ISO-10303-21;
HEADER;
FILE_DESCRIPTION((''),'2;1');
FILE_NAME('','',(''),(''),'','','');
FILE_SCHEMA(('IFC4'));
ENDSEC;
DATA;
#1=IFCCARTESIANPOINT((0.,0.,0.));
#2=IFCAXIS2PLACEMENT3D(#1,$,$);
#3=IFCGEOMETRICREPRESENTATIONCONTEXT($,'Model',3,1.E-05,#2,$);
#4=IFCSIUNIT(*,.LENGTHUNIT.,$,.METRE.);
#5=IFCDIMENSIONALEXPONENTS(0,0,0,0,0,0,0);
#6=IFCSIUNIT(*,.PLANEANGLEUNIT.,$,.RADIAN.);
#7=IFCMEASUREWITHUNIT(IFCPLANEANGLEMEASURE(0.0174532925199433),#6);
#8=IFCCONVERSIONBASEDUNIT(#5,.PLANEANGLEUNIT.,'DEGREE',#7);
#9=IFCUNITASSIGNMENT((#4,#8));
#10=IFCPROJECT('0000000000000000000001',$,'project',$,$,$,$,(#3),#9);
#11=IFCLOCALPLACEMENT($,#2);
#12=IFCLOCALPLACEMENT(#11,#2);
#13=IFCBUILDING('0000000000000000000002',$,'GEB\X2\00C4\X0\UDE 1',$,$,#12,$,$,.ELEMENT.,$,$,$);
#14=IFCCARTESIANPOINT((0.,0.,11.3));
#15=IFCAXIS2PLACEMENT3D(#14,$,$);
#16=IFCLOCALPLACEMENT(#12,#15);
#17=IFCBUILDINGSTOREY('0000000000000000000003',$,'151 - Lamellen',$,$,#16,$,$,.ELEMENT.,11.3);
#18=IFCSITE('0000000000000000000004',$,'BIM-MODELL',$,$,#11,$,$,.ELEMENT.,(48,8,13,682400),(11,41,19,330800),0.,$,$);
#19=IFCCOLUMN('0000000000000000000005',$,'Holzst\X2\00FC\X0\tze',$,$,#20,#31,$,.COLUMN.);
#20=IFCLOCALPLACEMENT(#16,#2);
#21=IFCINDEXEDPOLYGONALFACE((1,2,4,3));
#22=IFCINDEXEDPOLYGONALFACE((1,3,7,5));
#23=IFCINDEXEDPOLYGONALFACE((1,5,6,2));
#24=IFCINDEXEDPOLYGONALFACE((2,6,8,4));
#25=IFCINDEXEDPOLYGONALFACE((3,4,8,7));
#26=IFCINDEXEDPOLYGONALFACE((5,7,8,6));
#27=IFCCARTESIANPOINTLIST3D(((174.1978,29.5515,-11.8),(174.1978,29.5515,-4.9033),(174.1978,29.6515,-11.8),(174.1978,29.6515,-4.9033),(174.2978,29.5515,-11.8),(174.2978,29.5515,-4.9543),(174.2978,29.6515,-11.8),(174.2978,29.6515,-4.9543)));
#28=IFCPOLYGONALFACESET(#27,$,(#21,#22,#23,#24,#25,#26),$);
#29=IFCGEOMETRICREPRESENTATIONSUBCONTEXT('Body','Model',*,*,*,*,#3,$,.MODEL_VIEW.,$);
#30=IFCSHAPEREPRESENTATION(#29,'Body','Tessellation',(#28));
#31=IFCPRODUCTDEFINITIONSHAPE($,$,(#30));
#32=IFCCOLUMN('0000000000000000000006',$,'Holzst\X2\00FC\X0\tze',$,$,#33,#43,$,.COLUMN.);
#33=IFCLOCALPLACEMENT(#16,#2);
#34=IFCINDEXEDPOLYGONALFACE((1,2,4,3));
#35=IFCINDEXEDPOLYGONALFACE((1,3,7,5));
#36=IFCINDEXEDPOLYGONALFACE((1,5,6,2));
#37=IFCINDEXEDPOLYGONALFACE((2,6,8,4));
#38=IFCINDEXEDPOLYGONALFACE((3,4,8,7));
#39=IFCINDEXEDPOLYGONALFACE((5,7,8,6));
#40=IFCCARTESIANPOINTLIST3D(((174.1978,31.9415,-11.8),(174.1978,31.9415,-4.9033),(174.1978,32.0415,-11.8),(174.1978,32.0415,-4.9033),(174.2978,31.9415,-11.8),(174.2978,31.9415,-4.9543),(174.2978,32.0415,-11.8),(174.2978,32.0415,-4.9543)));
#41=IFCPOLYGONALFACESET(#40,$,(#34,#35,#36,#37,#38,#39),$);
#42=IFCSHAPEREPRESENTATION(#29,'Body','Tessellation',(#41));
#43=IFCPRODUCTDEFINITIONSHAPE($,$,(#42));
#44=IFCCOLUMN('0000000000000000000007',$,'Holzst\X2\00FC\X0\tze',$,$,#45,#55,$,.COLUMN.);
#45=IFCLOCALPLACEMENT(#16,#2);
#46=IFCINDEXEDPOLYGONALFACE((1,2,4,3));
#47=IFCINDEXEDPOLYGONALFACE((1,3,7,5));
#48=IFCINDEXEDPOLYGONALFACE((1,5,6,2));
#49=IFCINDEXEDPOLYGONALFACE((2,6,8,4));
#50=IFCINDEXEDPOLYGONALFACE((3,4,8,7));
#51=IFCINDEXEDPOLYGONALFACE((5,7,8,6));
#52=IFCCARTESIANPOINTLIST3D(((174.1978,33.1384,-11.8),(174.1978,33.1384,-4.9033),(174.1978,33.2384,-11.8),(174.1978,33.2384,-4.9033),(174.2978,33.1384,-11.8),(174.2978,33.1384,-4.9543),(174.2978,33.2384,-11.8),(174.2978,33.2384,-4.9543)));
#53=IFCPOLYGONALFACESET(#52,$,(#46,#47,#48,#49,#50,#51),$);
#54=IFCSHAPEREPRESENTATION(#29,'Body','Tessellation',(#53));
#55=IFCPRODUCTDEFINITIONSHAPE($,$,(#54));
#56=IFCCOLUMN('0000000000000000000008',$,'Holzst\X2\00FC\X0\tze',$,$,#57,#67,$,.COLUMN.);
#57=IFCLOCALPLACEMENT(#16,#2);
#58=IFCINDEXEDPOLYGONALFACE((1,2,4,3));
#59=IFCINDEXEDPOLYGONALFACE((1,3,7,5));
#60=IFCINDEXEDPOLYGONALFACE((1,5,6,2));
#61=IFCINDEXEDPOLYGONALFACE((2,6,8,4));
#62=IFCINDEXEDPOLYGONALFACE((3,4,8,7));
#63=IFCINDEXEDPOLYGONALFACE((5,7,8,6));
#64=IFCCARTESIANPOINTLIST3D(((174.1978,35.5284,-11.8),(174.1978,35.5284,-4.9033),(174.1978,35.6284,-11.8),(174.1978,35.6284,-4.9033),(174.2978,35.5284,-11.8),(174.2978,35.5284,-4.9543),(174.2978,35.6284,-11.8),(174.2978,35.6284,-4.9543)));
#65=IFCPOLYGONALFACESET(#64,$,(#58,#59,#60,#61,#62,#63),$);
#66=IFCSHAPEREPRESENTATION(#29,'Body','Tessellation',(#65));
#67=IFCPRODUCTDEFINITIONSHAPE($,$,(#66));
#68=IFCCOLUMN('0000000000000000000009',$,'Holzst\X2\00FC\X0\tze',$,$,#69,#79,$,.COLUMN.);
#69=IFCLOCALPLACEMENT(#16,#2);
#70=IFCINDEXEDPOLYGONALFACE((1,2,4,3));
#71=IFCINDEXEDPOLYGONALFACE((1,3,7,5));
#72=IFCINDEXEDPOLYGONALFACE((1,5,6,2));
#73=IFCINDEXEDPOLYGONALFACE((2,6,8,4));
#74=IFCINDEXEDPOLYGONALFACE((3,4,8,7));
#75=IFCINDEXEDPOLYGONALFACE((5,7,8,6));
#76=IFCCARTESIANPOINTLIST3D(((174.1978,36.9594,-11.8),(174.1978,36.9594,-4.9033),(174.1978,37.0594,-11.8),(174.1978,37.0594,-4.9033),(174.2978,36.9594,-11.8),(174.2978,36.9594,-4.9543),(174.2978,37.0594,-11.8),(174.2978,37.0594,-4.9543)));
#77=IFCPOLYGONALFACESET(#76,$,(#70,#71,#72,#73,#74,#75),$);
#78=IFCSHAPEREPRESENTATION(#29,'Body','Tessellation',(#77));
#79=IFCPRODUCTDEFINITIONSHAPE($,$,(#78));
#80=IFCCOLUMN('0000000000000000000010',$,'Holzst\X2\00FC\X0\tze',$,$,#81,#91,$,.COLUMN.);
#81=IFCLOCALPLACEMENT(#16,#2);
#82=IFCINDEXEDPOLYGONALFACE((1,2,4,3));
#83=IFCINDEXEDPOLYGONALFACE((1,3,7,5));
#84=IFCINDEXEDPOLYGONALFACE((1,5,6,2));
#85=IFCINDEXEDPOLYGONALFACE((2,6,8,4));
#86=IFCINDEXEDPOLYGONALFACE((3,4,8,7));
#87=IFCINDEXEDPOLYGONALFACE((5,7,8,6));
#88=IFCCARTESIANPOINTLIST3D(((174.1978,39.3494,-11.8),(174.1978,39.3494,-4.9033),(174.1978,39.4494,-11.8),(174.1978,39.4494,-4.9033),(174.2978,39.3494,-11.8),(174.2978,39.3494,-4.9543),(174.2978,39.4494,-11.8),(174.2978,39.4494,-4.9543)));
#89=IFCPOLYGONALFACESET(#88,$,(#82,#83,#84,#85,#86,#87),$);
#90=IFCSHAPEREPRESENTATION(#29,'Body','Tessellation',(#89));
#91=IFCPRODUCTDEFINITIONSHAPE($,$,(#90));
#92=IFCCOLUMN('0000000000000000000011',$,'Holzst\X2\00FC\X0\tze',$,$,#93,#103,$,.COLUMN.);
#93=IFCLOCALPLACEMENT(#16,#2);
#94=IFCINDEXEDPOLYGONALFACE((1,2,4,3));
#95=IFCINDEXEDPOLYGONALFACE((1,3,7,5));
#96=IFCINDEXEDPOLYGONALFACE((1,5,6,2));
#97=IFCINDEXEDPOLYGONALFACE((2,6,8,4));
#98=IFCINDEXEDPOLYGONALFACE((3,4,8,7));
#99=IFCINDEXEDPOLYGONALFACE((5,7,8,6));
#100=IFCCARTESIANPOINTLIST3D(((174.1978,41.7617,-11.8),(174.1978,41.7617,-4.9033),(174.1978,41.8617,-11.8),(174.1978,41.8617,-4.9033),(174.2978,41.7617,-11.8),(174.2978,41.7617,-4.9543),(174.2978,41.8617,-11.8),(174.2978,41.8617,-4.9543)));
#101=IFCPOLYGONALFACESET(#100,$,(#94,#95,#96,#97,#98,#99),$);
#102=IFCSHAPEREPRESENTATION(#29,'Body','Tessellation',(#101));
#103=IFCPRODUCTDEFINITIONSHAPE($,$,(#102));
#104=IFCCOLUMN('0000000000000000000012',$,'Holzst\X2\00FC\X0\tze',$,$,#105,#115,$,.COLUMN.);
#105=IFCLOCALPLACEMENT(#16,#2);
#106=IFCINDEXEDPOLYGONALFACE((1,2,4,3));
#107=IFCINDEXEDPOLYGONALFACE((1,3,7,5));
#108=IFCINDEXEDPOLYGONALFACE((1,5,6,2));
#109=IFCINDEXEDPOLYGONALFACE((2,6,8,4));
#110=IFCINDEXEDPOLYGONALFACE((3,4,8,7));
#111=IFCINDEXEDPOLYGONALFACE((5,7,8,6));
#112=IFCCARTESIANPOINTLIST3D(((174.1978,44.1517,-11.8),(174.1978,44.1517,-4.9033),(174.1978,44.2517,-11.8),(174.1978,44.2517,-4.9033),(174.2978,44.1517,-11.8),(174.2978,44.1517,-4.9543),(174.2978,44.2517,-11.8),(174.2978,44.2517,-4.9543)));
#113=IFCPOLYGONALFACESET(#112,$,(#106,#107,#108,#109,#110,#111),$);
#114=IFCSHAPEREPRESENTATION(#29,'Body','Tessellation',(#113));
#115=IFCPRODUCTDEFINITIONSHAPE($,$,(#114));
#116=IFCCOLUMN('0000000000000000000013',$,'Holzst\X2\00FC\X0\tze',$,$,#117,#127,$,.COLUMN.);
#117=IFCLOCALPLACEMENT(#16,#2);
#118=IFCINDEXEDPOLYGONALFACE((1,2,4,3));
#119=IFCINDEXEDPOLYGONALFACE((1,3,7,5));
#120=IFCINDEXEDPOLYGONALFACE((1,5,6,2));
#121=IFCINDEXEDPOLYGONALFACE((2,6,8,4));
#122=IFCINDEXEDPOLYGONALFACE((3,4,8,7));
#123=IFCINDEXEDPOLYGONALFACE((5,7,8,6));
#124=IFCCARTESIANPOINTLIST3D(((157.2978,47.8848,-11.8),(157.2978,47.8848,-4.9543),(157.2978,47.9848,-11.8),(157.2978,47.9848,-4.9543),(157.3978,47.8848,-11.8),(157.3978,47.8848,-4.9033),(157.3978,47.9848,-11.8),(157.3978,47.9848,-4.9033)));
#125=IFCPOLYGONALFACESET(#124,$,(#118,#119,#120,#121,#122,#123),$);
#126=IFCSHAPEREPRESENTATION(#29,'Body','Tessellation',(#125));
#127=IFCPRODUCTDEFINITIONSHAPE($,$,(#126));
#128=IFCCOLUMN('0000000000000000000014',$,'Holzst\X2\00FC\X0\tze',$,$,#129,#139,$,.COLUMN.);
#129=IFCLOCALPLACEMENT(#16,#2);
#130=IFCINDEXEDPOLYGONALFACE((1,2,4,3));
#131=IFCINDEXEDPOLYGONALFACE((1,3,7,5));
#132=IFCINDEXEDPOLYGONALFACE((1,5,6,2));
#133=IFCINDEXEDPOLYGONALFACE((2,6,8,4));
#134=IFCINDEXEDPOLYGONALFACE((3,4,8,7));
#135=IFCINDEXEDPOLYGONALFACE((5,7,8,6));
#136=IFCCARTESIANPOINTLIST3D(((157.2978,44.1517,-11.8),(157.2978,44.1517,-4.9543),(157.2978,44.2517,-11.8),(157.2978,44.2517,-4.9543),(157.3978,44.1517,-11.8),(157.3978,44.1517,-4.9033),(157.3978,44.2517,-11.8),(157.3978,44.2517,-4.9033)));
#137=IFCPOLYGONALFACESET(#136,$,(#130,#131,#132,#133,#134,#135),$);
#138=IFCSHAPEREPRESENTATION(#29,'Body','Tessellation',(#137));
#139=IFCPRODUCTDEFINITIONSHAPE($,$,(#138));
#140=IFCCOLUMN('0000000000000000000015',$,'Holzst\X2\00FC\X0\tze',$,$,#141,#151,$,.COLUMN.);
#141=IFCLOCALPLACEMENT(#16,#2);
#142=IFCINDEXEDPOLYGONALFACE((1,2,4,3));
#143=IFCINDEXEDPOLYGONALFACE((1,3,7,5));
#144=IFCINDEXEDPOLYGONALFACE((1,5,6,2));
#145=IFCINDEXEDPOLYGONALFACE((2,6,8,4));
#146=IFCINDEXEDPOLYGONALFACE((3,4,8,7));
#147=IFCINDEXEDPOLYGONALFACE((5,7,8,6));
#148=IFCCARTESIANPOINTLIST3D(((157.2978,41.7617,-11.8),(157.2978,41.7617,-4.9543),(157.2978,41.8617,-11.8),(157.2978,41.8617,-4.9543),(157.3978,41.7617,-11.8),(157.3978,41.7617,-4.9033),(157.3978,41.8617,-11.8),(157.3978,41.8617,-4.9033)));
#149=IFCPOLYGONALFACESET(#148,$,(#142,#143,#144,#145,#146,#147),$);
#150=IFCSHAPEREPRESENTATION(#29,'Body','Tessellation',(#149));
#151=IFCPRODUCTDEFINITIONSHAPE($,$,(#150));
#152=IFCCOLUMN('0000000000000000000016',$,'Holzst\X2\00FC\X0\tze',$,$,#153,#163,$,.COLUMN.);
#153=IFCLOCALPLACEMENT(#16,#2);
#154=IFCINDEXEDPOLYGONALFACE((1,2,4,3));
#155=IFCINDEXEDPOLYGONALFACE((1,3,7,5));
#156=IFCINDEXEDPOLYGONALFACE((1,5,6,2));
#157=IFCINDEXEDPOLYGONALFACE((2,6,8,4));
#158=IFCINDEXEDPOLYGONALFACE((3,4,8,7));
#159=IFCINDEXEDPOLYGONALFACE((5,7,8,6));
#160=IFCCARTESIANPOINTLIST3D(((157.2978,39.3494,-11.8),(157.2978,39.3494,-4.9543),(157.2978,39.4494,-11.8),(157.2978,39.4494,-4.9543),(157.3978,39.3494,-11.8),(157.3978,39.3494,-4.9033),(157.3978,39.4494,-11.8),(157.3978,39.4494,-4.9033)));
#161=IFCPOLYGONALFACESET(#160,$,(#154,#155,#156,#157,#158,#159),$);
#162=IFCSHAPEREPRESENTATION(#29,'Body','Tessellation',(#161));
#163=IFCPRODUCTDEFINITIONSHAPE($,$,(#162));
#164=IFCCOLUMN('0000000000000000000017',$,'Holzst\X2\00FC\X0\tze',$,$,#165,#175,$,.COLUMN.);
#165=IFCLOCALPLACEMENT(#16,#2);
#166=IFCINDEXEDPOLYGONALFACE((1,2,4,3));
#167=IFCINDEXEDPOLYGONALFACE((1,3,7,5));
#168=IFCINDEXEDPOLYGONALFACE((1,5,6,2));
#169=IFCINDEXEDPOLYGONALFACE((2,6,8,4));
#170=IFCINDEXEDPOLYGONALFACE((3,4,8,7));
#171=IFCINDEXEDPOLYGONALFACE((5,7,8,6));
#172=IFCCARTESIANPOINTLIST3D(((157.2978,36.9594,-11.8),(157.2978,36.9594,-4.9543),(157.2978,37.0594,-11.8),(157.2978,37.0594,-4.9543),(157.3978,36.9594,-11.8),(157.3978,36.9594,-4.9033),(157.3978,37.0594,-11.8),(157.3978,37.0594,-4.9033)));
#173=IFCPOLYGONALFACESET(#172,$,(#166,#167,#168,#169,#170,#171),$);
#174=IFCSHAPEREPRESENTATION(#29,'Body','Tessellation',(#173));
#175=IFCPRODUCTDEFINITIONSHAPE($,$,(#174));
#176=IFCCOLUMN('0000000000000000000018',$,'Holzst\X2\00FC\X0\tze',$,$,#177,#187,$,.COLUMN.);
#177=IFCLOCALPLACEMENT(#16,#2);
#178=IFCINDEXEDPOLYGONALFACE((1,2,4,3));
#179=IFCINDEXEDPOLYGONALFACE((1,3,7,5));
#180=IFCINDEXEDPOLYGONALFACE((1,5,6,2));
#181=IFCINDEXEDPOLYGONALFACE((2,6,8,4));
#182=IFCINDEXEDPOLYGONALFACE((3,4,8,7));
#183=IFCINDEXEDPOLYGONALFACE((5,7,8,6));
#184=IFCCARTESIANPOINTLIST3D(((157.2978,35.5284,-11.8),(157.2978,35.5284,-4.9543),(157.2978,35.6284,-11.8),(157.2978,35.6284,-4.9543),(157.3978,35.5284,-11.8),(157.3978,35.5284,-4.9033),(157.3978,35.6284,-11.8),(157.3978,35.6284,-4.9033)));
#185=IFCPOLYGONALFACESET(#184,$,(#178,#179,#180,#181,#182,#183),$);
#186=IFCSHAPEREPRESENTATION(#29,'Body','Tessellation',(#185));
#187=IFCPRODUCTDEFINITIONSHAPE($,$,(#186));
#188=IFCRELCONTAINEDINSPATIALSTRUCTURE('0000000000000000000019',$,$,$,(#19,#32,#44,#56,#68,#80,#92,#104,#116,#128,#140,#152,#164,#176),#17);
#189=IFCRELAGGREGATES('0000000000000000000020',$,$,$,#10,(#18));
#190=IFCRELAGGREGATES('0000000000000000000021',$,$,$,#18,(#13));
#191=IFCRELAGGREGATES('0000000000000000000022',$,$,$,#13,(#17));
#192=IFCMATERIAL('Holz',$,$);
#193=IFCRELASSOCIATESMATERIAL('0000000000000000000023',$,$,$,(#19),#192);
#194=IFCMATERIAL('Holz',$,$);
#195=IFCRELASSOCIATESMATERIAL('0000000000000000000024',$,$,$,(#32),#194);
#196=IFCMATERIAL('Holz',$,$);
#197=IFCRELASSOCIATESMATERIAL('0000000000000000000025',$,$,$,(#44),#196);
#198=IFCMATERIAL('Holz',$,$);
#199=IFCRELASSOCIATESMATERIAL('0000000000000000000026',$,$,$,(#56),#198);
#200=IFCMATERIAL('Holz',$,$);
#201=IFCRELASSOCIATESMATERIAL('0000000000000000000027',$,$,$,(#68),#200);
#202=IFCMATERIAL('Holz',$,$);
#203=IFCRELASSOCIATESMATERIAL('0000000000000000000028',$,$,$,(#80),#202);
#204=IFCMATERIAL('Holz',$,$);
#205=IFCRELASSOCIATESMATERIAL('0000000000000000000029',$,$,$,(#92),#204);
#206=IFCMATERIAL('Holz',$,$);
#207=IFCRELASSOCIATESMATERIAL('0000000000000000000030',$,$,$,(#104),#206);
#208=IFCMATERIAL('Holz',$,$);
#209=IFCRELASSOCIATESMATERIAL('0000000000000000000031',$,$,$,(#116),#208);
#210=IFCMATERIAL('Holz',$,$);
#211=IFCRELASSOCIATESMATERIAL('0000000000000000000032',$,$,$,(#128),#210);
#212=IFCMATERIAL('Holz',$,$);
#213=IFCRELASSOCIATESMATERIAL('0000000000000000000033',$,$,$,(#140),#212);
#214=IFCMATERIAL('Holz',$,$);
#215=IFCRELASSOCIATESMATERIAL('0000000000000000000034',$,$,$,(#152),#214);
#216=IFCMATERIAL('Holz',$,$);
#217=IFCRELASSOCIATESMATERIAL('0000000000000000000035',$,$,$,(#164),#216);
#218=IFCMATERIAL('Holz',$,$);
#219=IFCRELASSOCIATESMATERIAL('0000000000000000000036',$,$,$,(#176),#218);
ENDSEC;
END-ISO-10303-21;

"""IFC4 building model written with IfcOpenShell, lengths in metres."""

from ifc_helpers import new_model, entity, si_unit, converted_unit, frame, frame_2d, origin, origin_with_axes, place, context, subcontext, project, spatial, rectangle, extrude, clip, halfspace, material, element, save


model = new_model("IFC4")

# Units and contexts
model_context = context("Model", 3, precision=1e-05, world=origin())
body_context = subcontext(model_context, "Body", "Model", "MODEL_VIEW")
ifc_project = project(units=[si_unit("LENGTHUNIT", "METRE"), converted_unit("PLANEANGLEUNIT", "DEGREE", entity("IfcPlaneAngleMeasure", 0.0174532925199433), si_unit("PLANEANGLEUNIT", "RADIAN"), dimensions=[0, 0, 0, 0, 0, 0, 0])], contexts=[model_context])

# Site, building, storey
site_placement = place(None, origin())
site = spatial("IfcSite", under=ifc_project, at=site_placement, Name="BIM-MODELL", CompositionType="ELEMENT", RefLatitude=(48, 8, 13, 682400), RefLongitude=(11, 41, 19, 330800), RefElevation=0.0)
building_placement = place(site_placement, origin())
building = spatial("IfcBuilding", under=site, at=building_placement, Name="GEBÄUDE 1", CompositionType="ELEMENT")
storey_placement = place(building_placement, frame((0.0, 0.0, 11.3)))
storey = spatial("IfcBuildingStorey", under=building, at=storey_placement, Name="151 - Lamellen", CompositionType="ELEMENT", Elevation=11.3)

# Columns
ifc_material_1 = material(Name="Holz")
column_1_placement = place(storey_placement, frame((174.2978, 29.5515, -11.8)))
element("IfcColumn", 1, at=column_1_placement, inside=storey, material=ifc_material_1, Name="Holzstütze", PredefinedType="COLUMN", context=body_context, shape_type="Clipping", body=[
    clip(extrude(rectangle(XDim=0.1, YDim=0.1, at=frame_2d((-0.05, 0.05), x_axis=(0.0, 1.0))), origin_with_axes(), (0.0, 0.0, 1.0), 6.8967), halfspace(frame((-0.05, 0.05, 6.8712), z_axis=(-0.45399, 0.0, -0.891007), x_axis=(0.891007, 0.0, -0.45399)), True)),
])
ifc_material_2 = material(Name="Holz")
column_2_placement = place(storey_placement, frame((174.2978, 31.9415, -11.8)))
element("IfcColumn", 2, at=column_2_placement, inside=storey, material=ifc_material_2, Name="Holzstütze", PredefinedType="COLUMN", context=body_context, shape_type="Clipping", body=[
    clip(extrude(rectangle(XDim=0.1, YDim=0.1, at=frame_2d((-0.05, 0.05), x_axis=(0.0, 1.0))), origin_with_axes(), (0.0, 0.0, 1.0), 6.8967), halfspace(frame((-0.05, 0.05, 6.8712), z_axis=(-0.45399, 0.0, -0.891007), x_axis=(0.891007, 0.0, -0.45399)), True)),
])
ifc_material_3 = material(Name="Holz")
column_3_placement = place(storey_placement, frame((174.2978, 33.1384, -11.8)))
element("IfcColumn", 3, at=column_3_placement, inside=storey, material=ifc_material_3, Name="Holzstütze", PredefinedType="COLUMN", context=body_context, shape_type="Clipping", body=[
    clip(extrude(rectangle(XDim=0.1, YDim=0.1, at=frame_2d((-0.05, 0.05), x_axis=(0.0, 1.0))), origin_with_axes(), (0.0, 0.0, 1.0), 6.8967), halfspace(frame((-0.05, 0.05, 6.8712), z_axis=(-0.45399, 0.0, -0.891007), x_axis=(0.891007, 0.0, -0.45399)), True)),
])
ifc_material_4 = material(Name="Holz")
column_4_placement = place(storey_placement, frame((174.2978, 35.5284, -11.8)))
element("IfcColumn", 4, at=column_4_placement, inside=storey, material=ifc_material_4, Name="Holzstütze", PredefinedType="COLUMN", context=body_context, shape_type="Clipping", body=[
    clip(extrude(rectangle(XDim=0.1, YDim=0.1, at=frame_2d((-0.05, 0.05), x_axis=(0.0, 1.0))), origin_with_axes(), (0.0, 0.0, 1.0), 6.8967), halfspace(frame((-0.05, 0.05, 6.8712), z_axis=(-0.45399, 0.0, -0.891007), x_axis=(0.891007, 0.0, -0.45399)), True)),
])
ifc_material_5 = material(Name="Holz")
column_5_placement = place(storey_placement, frame((174.2978, 36.9594, -11.8)))
element("IfcColumn", 5, at=column_5_placement, inside=storey, material=ifc_material_5, Name="Holzstütze", PredefinedType="COLUMN", context=body_context, shape_type="Clipping", body=[
    clip(extrude(rectangle(XDim=0.1, YDim=0.1, at=frame_2d((-0.05, 0.05), x_axis=(0.0, 1.0))), origin_with_axes(), (0.0, 0.0, 1.0), 6.8967), halfspace(frame((-0.05, 0.05, 6.8712), z_axis=(-0.45399, 0.0, -0.891007), x_axis=(0.891007, 0.0, -0.45399)), True)),
])
ifc_material_6 = material(Name="Holz")
column_6_placement = place(storey_placement, frame((174.2978, 39.3494, -11.8)))
element("IfcColumn", 6, at=column_6_placement, inside=storey, material=ifc_material_6, Name="Holzstütze", PredefinedType="COLUMN", context=body_context, shape_type="Clipping", body=[
    clip(extrude(rectangle(XDim=0.1, YDim=0.1, at=frame_2d((-0.05, 0.05), x_axis=(0.0, 1.0))), origin_with_axes(), (0.0, 0.0, 1.0), 6.8967), halfspace(frame((-0.05, 0.05, 6.8712), z_axis=(-0.45399, 0.0, -0.891007), x_axis=(0.891007, 0.0, -0.45399)), True)),
])
ifc_material_7 = material(Name="Holz")
column_7_placement = place(storey_placement, frame((174.2978, 41.7617, -11.8)))
element("IfcColumn", 7, at=column_7_placement, inside=storey, material=ifc_material_7, Name="Holzstütze", PredefinedType="COLUMN", context=body_context, shape_type="Clipping", body=[
    clip(extrude(rectangle(XDim=0.1, YDim=0.1, at=frame_2d((-0.05, 0.05), x_axis=(0.0, 1.0))), origin_with_axes(), (0.0, 0.0, 1.0), 6.8967), halfspace(frame((-0.05, 0.05, 6.8712), z_axis=(-0.45399, 0.0, -0.891007), x_axis=(0.891007, 0.0, -0.45399)), True)),
])
ifc_material_8 = material(Name="Holz")
column_8_placement = place(storey_placement, frame((174.2978, 44.1517, -11.8)))
element("IfcColumn", 8, at=column_8_placement, inside=storey, material=ifc_material_8, Name="Holzstütze", PredefinedType="COLUMN", context=body_context, shape_type="Clipping", body=[
    clip(extrude(rectangle(XDim=0.1, YDim=0.1, at=frame_2d((-0.05, 0.05), x_axis=(0.0, 1.0))), origin_with_axes(), (0.0, 0.0, 1.0), 6.8967), halfspace(frame((-0.05, 0.05, 6.8712), z_axis=(-0.45399, 0.0, -0.891007), x_axis=(0.891007, 0.0, -0.45399)), True)),
])
ifc_material_9 = material(Name="Holz")
column_9_placement = place(storey_placement, frame((157.3978, 47.8848, -11.8)))
element("IfcColumn", 9, at=column_9_placement, inside=storey, material=ifc_material_9, Name="Holzstütze", PredefinedType="COLUMN", context=body_context, shape_type="Clipping", body=[
    clip(extrude(rectangle(XDim=0.1, YDim=0.1, at=frame_2d((-0.05, 0.05), x_axis=(0.0, 1.0))), origin_with_axes(), (0.0, 0.0, 1.0), 6.8967), halfspace(frame((-0.05, 0.05, 6.8712), z_axis=(0.45399, 0.0, -0.891007), x_axis=(0.0, 1.0, 0.0)), True)),
])
ifc_material_10 = material(Name="Holz")
column_10_placement = place(storey_placement, frame((157.3978, 44.1517, -11.8)))
element("IfcColumn", 10, at=column_10_placement, inside=storey, material=ifc_material_10, Name="Holzstütze", PredefinedType="COLUMN", context=body_context, shape_type="Clipping", body=[
    clip(extrude(rectangle(XDim=0.1, YDim=0.1, at=frame_2d((-0.05, 0.05), x_axis=(0.0, 1.0))), origin_with_axes(), (0.0, 0.0, 1.0), 6.8967), halfspace(frame((-0.05, 0.05, 6.8712), z_axis=(0.45399, 0.0, -0.891007), x_axis=(-0.891007, 0.0, -0.45399)), True)),
])
ifc_material_11 = material(Name="Holz")
column_11_placement = place(storey_placement, frame((157.3978, 41.7617, -11.8)))
element("IfcColumn", 11, at=column_11_placement, inside=storey, material=ifc_material_11, Name="Holzstütze", PredefinedType="COLUMN", context=body_context, shape_type="Clipping", body=[
    clip(extrude(rectangle(XDim=0.1, YDim=0.1, at=frame_2d((-0.05, 0.05), x_axis=(0.0, 1.0))), origin_with_axes(), (0.0, 0.0, 1.0), 6.8967), halfspace(frame((-0.05, 0.05, 6.8712), z_axis=(0.45399, 0.0, -0.891007), x_axis=(-0.891007, 0.0, -0.45399)), True)),
])
ifc_material_12 = material(Name="Holz")
column_12_placement = place(storey_placement, frame((157.3978, 39.3494, -11.8)))
element("IfcColumn", 12, at=column_12_placement, inside=storey, material=ifc_material_12, Name="Holzstütze", PredefinedType="COLUMN", context=body_context, shape_type="Clipping", body=[
    clip(extrude(rectangle(XDim=0.1, YDim=0.1, at=frame_2d((-0.05, 0.05), x_axis=(0.0, 1.0))), origin_with_axes(), (0.0, 0.0, 1.0), 6.8967), halfspace(frame((-0.05, 0.05, 6.8712), z_axis=(0.45399, 0.0, -0.891007), x_axis=(-0.891007, 0.0, -0.45399)), True)),
])
ifc_material_13 = material(Name="Holz")
column_13_placement = place(storey_placement, frame((157.3978, 36.9594, -11.8)))
element("IfcColumn", 13, at=column_13_placement, inside=storey, material=ifc_material_13, Name="Holzstütze", PredefinedType="COLUMN", context=body_context, shape_type="Clipping", body=[
    clip(extrude(rectangle(XDim=0.1, YDim=0.1, at=frame_2d((-0.05, 0.05), x_axis=(0.0, 1.0))), origin_with_axes(), (0.0, 0.0, 1.0), 6.8967), halfspace(frame((-0.05, 0.05, 6.8712), z_axis=(0.45399, 0.0, -0.891007), x_axis=(-0.891007, 0.0, -0.45399)), True)),
])
ifc_material_14 = material(Name="Holz")
column_14_placement = place(storey_placement, frame((157.3978, 35.5284, -11.8)))
element("IfcColumn", 14, at=column_14_placement, inside=storey, material=ifc_material_14, Name="Holzstütze", PredefinedType="COLUMN", context=body_context, shape_type="Clipping", body=[
    clip(extrude(rectangle(XDim=0.1, YDim=0.1, at=frame_2d((-0.05, 0.05), x_axis=(0.0, 1.0))), origin_with_axes(), (0.0, 0.0, 1.0), 6.8967), halfspace(frame((-0.05, 0.05, 6.8712), z_axis=(0.45399, 0.0, -0.891007), x_axis=(-0.891007, 0.0, -0.45399)), True)),
])

save(model, "model.ifc")
